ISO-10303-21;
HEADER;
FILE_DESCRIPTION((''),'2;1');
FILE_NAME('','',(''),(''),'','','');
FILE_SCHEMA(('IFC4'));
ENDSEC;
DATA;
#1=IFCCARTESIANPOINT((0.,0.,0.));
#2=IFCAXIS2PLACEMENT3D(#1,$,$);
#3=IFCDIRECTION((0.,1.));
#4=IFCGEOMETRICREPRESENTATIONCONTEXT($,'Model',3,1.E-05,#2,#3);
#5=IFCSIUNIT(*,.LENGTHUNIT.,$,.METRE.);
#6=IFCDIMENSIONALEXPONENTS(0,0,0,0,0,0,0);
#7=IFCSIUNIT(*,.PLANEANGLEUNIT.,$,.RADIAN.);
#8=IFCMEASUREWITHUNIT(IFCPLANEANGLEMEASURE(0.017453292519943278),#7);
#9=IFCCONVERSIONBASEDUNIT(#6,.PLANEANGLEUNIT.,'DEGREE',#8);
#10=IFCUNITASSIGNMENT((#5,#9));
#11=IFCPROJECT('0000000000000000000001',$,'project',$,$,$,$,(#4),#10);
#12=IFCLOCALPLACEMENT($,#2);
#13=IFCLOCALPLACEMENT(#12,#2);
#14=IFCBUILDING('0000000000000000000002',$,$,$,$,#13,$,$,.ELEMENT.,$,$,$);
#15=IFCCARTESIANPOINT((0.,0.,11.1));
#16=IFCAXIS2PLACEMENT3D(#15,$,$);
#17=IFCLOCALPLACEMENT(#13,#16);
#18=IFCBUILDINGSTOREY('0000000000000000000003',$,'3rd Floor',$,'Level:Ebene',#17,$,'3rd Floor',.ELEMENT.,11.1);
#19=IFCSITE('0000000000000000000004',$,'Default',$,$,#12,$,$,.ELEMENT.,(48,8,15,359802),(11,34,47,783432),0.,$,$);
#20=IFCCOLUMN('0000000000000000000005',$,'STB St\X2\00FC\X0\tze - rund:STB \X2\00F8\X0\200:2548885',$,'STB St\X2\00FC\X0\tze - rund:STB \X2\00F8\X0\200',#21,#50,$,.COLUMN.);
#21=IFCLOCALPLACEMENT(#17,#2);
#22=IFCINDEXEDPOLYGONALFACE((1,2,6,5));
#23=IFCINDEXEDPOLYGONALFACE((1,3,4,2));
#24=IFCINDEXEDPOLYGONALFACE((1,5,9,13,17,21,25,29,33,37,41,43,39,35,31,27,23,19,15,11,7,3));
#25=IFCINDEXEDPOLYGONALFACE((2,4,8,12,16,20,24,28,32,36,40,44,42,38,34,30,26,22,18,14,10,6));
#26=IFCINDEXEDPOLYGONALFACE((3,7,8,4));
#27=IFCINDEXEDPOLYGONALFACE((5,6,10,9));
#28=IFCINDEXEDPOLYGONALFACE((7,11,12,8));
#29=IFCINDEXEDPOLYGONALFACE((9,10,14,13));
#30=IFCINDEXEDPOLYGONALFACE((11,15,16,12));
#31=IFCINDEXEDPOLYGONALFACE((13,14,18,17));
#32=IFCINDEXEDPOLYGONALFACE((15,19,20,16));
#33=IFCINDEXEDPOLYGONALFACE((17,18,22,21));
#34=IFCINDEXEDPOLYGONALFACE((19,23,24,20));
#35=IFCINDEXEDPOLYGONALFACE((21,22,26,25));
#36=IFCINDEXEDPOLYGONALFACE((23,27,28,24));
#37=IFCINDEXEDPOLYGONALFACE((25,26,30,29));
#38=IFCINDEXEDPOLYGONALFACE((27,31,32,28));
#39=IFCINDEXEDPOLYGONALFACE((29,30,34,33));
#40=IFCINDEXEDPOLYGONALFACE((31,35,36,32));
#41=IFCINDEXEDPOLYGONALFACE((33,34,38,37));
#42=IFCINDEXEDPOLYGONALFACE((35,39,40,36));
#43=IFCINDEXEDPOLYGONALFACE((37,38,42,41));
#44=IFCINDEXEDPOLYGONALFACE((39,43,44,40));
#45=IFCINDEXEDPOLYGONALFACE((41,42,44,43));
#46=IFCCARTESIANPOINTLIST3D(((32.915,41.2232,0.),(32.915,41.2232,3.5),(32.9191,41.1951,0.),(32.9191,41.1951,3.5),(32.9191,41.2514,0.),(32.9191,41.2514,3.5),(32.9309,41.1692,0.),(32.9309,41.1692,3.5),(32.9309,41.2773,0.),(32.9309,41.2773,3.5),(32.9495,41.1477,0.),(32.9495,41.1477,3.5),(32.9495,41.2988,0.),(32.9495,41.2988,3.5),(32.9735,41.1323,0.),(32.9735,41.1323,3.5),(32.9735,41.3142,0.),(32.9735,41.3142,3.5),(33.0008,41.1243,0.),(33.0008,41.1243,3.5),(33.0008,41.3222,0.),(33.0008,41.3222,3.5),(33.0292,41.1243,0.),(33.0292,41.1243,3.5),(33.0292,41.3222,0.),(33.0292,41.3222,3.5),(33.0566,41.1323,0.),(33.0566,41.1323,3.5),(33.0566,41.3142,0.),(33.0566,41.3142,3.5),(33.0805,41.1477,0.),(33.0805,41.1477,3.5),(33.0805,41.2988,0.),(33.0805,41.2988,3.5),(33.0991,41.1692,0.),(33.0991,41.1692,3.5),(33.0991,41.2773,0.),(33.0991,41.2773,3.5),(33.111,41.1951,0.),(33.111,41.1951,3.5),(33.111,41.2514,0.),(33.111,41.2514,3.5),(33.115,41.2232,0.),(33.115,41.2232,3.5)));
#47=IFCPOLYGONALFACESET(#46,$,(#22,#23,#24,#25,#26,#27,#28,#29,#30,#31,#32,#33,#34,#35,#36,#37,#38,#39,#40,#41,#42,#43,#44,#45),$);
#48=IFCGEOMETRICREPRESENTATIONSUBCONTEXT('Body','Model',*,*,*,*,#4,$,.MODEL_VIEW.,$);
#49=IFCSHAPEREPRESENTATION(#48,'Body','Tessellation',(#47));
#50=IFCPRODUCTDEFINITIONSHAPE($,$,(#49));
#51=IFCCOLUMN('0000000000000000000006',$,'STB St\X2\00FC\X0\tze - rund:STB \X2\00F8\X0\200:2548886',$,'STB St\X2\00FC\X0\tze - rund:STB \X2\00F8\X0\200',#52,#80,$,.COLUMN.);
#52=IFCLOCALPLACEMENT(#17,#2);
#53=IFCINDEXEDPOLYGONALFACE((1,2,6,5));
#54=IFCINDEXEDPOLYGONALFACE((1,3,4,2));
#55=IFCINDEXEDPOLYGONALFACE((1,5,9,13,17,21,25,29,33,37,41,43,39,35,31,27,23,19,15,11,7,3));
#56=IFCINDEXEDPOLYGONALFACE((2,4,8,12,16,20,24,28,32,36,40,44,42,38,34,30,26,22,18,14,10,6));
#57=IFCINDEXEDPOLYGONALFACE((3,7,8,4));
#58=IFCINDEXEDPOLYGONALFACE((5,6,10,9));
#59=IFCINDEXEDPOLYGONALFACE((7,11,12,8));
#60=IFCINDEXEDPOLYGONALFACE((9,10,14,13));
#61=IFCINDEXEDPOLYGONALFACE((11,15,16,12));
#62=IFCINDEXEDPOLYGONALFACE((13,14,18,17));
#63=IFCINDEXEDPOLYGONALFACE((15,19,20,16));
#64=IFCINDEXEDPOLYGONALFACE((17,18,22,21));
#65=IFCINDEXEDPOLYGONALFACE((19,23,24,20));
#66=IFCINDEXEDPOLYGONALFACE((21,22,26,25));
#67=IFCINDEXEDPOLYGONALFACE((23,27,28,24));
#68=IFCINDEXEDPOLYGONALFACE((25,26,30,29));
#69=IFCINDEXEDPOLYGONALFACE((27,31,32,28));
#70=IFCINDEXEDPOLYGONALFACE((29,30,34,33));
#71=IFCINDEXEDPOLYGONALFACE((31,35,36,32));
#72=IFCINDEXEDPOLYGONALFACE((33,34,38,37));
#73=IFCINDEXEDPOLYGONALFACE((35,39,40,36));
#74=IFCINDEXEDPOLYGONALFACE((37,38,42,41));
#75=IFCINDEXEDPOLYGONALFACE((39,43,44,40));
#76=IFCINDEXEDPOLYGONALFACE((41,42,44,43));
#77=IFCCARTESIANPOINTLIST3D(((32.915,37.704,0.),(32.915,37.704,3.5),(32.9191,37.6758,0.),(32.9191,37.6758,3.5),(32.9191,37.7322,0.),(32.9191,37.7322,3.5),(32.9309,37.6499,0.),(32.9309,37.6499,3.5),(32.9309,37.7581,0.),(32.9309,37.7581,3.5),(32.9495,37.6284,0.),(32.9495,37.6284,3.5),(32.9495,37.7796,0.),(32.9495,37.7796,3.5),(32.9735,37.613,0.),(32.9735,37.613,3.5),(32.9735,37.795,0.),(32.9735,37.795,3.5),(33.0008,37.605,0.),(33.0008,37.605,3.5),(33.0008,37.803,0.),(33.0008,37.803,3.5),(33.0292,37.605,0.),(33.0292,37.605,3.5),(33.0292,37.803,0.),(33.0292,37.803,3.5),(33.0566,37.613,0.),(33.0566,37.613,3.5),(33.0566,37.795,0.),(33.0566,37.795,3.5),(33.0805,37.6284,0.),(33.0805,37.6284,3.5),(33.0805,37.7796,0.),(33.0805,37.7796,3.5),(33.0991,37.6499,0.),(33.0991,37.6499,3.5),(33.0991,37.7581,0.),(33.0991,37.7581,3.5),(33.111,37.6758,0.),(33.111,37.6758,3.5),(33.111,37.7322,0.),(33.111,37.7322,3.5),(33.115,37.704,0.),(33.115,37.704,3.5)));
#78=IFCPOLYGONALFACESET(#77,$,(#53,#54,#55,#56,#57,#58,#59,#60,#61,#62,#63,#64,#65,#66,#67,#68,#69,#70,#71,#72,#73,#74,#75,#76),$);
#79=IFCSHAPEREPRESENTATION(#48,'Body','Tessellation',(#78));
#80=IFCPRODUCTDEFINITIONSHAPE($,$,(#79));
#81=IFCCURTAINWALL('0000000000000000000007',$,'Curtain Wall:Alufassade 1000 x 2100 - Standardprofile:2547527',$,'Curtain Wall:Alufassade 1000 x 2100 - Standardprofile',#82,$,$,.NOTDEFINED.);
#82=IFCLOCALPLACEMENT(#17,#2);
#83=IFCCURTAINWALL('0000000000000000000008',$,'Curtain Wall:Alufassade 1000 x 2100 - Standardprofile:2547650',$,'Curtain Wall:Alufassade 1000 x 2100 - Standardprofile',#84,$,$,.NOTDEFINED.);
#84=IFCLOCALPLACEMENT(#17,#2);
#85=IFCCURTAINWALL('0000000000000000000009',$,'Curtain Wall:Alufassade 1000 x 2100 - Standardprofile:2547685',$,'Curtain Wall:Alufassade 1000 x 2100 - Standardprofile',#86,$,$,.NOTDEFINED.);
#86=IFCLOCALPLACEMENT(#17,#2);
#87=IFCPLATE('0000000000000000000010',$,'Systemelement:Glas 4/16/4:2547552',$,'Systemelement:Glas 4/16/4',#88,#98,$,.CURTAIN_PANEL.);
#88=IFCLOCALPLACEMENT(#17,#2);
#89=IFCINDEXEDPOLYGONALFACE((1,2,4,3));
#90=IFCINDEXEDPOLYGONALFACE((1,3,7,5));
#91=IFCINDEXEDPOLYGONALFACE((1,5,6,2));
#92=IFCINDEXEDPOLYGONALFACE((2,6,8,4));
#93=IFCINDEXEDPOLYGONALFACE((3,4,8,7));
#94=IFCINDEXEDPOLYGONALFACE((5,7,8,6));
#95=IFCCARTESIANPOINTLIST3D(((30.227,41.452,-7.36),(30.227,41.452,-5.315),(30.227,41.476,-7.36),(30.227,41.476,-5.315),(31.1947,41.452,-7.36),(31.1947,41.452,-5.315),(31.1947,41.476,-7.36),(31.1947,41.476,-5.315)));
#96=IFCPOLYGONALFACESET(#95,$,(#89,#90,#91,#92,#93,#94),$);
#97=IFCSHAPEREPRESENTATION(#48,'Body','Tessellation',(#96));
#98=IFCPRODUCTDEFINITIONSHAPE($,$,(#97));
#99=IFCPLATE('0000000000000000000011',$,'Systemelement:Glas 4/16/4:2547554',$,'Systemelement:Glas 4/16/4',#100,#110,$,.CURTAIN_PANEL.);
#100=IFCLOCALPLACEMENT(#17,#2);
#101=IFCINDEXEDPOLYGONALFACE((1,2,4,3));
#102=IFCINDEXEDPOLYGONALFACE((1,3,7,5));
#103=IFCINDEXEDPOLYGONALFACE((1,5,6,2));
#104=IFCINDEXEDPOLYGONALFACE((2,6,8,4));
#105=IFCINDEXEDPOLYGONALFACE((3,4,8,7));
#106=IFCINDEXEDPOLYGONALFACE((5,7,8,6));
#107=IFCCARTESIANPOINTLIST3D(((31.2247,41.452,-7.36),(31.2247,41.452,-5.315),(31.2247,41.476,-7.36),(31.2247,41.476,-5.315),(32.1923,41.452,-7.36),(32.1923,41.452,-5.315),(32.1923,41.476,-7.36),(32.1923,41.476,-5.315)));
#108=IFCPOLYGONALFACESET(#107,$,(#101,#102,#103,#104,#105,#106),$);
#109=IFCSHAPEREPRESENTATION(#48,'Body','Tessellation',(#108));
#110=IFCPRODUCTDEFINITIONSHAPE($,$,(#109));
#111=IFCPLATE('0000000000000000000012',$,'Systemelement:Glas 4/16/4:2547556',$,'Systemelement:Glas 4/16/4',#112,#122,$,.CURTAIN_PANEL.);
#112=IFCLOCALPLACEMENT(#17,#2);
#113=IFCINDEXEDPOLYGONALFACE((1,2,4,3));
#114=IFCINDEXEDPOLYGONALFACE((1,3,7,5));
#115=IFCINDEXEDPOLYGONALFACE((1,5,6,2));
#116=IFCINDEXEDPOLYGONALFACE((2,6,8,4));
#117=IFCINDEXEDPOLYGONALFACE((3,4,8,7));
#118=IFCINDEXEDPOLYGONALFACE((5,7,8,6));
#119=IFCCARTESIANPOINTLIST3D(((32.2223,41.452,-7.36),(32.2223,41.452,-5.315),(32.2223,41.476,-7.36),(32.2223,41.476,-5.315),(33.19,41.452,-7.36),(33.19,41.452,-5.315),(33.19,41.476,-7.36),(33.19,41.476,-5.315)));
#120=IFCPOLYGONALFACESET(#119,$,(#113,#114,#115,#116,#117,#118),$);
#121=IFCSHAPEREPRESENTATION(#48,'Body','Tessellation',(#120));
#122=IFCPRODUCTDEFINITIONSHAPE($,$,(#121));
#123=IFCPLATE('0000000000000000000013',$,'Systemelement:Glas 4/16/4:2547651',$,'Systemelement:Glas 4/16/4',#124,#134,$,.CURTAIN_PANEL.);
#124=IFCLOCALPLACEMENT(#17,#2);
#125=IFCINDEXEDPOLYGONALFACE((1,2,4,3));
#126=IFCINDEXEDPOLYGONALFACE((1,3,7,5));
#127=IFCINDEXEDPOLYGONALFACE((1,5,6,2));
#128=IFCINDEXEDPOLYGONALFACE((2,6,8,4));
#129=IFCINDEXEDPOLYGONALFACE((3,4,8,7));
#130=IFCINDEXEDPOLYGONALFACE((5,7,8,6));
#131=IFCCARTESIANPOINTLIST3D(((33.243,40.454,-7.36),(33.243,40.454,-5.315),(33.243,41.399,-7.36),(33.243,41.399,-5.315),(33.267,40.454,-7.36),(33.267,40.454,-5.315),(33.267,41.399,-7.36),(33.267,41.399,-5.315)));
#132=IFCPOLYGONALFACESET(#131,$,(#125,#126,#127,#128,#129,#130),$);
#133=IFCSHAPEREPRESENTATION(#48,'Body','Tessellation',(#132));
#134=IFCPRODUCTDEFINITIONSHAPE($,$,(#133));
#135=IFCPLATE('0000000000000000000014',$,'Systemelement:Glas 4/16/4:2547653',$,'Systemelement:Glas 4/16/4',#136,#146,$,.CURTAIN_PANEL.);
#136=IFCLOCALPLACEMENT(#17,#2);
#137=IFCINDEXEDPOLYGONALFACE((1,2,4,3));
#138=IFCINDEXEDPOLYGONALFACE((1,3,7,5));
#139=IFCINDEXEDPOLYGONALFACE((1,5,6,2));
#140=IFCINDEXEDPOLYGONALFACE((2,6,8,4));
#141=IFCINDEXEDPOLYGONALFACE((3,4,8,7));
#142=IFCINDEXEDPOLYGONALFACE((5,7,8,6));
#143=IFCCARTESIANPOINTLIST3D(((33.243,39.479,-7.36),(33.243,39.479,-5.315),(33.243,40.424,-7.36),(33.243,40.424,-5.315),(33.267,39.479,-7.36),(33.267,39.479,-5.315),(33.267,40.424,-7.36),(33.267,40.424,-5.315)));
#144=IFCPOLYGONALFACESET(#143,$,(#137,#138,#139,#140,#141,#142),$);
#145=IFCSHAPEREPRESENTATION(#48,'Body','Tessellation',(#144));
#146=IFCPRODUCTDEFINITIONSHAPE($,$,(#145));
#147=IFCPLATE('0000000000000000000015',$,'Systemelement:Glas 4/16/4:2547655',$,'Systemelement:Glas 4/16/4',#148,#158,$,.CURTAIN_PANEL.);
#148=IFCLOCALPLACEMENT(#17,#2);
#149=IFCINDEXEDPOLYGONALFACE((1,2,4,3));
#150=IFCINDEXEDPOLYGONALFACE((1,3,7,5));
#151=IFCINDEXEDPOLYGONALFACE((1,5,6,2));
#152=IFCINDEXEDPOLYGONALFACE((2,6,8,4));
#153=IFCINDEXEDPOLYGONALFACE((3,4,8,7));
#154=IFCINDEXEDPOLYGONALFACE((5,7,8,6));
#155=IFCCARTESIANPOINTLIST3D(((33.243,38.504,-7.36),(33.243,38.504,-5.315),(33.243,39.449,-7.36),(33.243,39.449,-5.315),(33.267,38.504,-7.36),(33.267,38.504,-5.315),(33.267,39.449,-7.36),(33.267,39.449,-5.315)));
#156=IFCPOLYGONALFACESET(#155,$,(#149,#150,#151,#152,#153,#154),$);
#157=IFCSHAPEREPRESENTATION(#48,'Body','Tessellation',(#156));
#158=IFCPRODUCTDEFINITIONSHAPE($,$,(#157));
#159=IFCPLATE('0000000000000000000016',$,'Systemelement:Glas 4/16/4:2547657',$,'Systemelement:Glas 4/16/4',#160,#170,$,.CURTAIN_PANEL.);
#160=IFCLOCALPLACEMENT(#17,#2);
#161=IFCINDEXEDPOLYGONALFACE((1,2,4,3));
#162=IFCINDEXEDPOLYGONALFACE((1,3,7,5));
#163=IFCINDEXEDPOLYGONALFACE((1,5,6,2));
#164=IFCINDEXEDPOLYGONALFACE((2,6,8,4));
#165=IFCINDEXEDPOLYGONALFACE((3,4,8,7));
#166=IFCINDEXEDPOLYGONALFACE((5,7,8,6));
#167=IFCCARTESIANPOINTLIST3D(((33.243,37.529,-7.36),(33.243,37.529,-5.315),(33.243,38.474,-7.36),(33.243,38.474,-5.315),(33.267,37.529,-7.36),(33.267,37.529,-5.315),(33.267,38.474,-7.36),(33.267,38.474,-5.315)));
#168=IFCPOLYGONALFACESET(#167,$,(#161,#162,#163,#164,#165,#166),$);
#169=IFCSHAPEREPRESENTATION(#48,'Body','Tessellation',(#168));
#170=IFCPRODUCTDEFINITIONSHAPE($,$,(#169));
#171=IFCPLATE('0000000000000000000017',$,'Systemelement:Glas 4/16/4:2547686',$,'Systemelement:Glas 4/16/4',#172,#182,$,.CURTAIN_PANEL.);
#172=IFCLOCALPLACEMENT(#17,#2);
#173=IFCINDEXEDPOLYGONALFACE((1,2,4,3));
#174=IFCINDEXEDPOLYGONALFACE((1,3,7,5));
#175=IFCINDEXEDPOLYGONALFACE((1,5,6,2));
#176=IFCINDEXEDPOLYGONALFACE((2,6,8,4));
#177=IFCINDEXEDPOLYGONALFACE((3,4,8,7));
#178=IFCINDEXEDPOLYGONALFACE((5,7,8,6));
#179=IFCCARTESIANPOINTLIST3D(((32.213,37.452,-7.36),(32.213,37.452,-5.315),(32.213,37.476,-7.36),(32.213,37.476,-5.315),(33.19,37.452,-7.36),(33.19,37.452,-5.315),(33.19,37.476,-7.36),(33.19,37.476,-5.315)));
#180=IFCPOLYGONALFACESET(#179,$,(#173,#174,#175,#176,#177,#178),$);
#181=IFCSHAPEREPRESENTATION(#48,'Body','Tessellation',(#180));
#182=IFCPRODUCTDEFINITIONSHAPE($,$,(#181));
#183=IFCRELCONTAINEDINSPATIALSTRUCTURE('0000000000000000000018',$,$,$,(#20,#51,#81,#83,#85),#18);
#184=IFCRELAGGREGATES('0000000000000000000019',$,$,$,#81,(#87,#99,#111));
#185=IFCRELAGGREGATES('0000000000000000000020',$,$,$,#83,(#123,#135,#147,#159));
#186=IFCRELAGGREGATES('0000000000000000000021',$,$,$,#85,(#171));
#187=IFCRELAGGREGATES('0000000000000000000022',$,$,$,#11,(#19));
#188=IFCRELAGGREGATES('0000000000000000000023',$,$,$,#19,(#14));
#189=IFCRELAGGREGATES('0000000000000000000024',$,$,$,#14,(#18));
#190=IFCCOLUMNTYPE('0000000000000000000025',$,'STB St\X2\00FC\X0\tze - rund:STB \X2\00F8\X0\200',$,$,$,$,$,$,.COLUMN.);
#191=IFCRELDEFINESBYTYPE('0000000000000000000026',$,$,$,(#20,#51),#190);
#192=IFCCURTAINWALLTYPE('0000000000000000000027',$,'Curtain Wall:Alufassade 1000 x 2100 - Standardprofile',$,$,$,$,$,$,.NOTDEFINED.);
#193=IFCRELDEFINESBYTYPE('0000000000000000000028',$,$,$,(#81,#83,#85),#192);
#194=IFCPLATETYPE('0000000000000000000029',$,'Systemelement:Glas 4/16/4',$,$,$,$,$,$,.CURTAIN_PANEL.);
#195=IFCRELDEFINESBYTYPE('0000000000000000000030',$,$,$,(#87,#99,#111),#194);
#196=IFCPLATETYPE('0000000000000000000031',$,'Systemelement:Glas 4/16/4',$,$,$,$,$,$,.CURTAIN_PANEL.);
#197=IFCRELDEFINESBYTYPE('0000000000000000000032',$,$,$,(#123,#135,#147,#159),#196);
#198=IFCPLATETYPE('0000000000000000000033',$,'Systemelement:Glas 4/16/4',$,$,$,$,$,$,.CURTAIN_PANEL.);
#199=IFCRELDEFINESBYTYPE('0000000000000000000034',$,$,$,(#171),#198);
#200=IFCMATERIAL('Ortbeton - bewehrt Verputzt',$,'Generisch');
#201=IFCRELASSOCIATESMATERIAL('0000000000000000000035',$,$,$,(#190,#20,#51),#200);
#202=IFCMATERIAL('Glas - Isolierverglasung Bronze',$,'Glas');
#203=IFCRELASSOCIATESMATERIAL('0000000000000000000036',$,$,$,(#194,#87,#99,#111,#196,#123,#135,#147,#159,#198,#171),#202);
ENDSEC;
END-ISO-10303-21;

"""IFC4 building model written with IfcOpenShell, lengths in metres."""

from ifc_helpers import new_model, entity, si_unit, converted_unit, direction, frame, origin, place, context, subcontext, project, spatial, arc, indexed_curve, outline, extrude, source, transform, mapped, material, type_object, type_shapes, element, aggregate, save


model = new_model("IFC4")

# Units and contexts
model_context = context("Model", 3, precision=1e-05, world=origin(), true_north=direction((0.0, 1.0)))
body_context = subcontext(model_context, "Body", "Model", "MODEL_VIEW")
ifc_project = project(units=[si_unit("LENGTHUNIT", "METRE"), converted_unit("PLANEANGLEUNIT", "DEGREE", entity("IfcPlaneAngleMeasure", 0.017453292519943278), si_unit("PLANEANGLEUNIT", "RADIAN"), dimensions=[0, 0, 0, 0, 0, 0, 0])], contexts=[model_context])

# Site, building, storey
site_placement = place(None, origin())
site = spatial("IfcSite", under=ifc_project, at=site_placement, Name="Default", CompositionType="ELEMENT", RefLatitude=(48, 8, 15, 359802), RefLongitude=(11, 34, 47, 783432), RefElevation=0.0)
building_placement = place(site_placement, origin())
building = spatial("IfcBuilding", under=site, at=building_placement, CompositionType="ELEMENT")
storey_placement = place(building_placement, frame((0.0, 0.0, 11.1)))
storey = spatial("IfcBuildingStorey", under=building, at=storey_placement, Name="3rd Floor", ObjectType="Level:Ebene", LongName="3rd Floor", CompositionType="ELEMENT", Elevation=11.1)

# Columns
ifc_material_1 = material(Name="Ortbeton - bewehrt Verputzt", Category="Generisch")
column_type_1 = type_object("IfcColumnType", Name="STB Stütze - rund:STB ø200", PredefinedType="COLUMN", material=ifc_material_1)
shared_shape_1 = source(origin(), body_context, "Body", "SweptSolid", [
    extrude(outline(indexed_curve([(-0.1, 0.0), (0.0, -0.1), (0.1, 0.0), (0.0, 0.1)], segments=[arc(1, 2, 3), arc(3, 4, 1)], self_intersect=False)), frame((0.0, 0.0, 11.1)), (0.0, 0.0, 1.0), 3.5),
])
type_shapes(column_type_1, [shared_shape_1])
for number, where, name in (
    (1, (33.015, 41.2232, -11.1), "STB Stütze - rund:STB ø200:2548885"),
    (2, (33.015, 37.704, -11.1), "STB Stütze - rund:STB ø200:2548886"),
):
    element("IfcColumn", number, at=place(storey_placement, frame(where)), inside=storey, type_object=column_type_1, material=ifc_material_1, Name=name, ObjectType="STB Stütze - rund:STB ø200", PredefinedType="COLUMN", context=body_context, shape_type="MappedRepresentation", body=[
        mapped(shared_shape_1, transform((0.0, 0.0, 0.0), scale=1.0)),
    ])

# Curtain walls
curtain_wall_type = type_object("IfcCurtainWallType", Name="Curtain Wall:Alufassade 1000 x 2100 - Standardprofile", PredefinedType="NOTDEFINED")
curtain_wall_1_placement = place(storey_placement, frame((0.0, 0.0, -11.1)))
curtain_wall_1 = element("IfcCurtainWall", 3, at=curtain_wall_1_placement, inside=storey, type_object=curtain_wall_type, Name="Curtain Wall:Alufassade 1000 x 2100 - Standardprofile:2547527", ObjectType="Curtain Wall:Alufassade 1000 x 2100 - Standardprofile", PredefinedType="NOTDEFINED")
curtain_wall_2_placement = place(storey_placement, frame((0.0, 0.0, -11.1)))
curtain_wall_2 = element("IfcCurtainWall", 4, at=curtain_wall_2_placement, inside=storey, type_object=curtain_wall_type, Name="Curtain Wall:Alufassade 1000 x 2100 - Standardprofile:2547650", ObjectType="Curtain Wall:Alufassade 1000 x 2100 - Standardprofile", PredefinedType="NOTDEFINED")

# Curtain wall
curtain_wall_3_placement = place(storey_placement, frame((0.0, 0.0, -11.1)))
curtain_wall_3 = element("IfcCurtainWall", 5, at=curtain_wall_3_placement, inside=storey, type_object=curtain_wall_type, Name="Curtain Wall:Alufassade 1000 x 2100 - Standardprofile:2547685", ObjectType="Curtain Wall:Alufassade 1000 x 2100 - Standardprofile", PredefinedType="NOTDEFINED")

# Plates
ifc_material_2 = material(Name="Glas - Isolierverglasung Bronze", Category="Glas")
plate_type_1 = type_object("IfcPlateType", Name="Systemelement:Glas 4/16/4", PredefinedType="CURTAIN_PANEL", material=ifc_material_2)
shared_shape_2 = source(origin(), body_context, "Body", "SweptSolid", [
    extrude(outline(indexed_curve([(-0.012, -0.4838), (0.012, -0.4838), (0.012, 0.4838), (-0.012, 0.4838), (-0.012, -0.4838)], self_intersect=False)), frame((0.0, 0.0, 0.0), z_axis=(0.0, 0.0, 1.0), x_axis=(0.0, 1.0, 0.0)), (0.0, 0.0, 1.0), 2.045),
])
type_shapes(plate_type_1, [shared_shape_2])
plate_1_placement = place(curtain_wall_1_placement, frame((30.7108, 41.464, 3.74)))
plate_1 = element("IfcPlate", 6, at=plate_1_placement, type_object=plate_type_1, material=ifc_material_2, Name="Systemelement:Glas 4/16/4:2547552", ObjectType="Systemelement:Glas 4/16/4", PredefinedType="CURTAIN_PANEL", context=body_context, shape_type="MappedRepresentation", body=[
    mapped(shared_shape_2, transform((0.0, 0.0, 0.0), scale=1.0)),
])
plate_2_placement = place(curtain_wall_1_placement, frame((31.7085, 41.464, 3.74)))
plate_2 = element("IfcPlate", 7, at=plate_2_placement, type_object=plate_type_1, material=ifc_material_2, Name="Systemelement:Glas 4/16/4:2547554", ObjectType="Systemelement:Glas 4/16/4", PredefinedType="CURTAIN_PANEL", context=body_context, shape_type="MappedRepresentation", body=[
    mapped(shared_shape_2, transform((0.0, 0.0, 0.0), scale=1.0)),
])
plate_3_placement = place(curtain_wall_1_placement, frame((32.7062, 41.464, 3.74)))
plate_3 = element("IfcPlate", 8, at=plate_3_placement, type_object=plate_type_1, material=ifc_material_2, Name="Systemelement:Glas 4/16/4:2547556", ObjectType="Systemelement:Glas 4/16/4", PredefinedType="CURTAIN_PANEL", context=body_context, shape_type="MappedRepresentation", body=[
    mapped(shared_shape_2, transform((0.0, 0.0, 0.0), scale=1.0)),
])
aggregate(curtain_wall_1, [plate_1, plate_2, plate_3])
plate_type_2 = type_object("IfcPlateType", Name="Systemelement:Glas 4/16/4", PredefinedType="CURTAIN_PANEL", material=ifc_material_2)
shared_shape_3 = source(origin(), body_context, "Body", "SweptSolid", [
    extrude(outline(indexed_curve([(-0.012, -0.4725), (0.012, -0.4725), (0.012, 0.4725), (-0.012, 0.4725), (-0.012, -0.4725)], self_intersect=False)), frame((0.0, 0.0, 0.0), z_axis=(0.0, 0.0, 1.0), x_axis=(0.0, 1.0, 0.0)), (0.0, 0.0, 1.0), 2.045),
])
type_shapes(plate_type_2, [shared_shape_3])
plate_4_placement = place(curtain_wall_2_placement, frame((33.255, 40.9265, 3.74), z_axis=(0.0, 0.0, 1.0), x_axis=(0.0, -1.0, 0.0)))
plate_4 = element("IfcPlate", 9, at=plate_4_placement, type_object=plate_type_2, material=ifc_material_2, Name="Systemelement:Glas 4/16/4:2547651", ObjectType="Systemelement:Glas 4/16/4", PredefinedType="CURTAIN_PANEL", context=body_context, shape_type="MappedRepresentation", body=[
    mapped(shared_shape_3, transform((0.0, 0.0, 0.0), scale=1.0)),
])
plate_5_placement = place(curtain_wall_2_placement, frame((33.255, 39.9515, 3.74), z_axis=(0.0, 0.0, 1.0), x_axis=(0.0, -1.0, 0.0)))
plate_5 = element("IfcPlate", 10, at=plate_5_placement, type_object=plate_type_2, material=ifc_material_2, Name="Systemelement:Glas 4/16/4:2547653", ObjectType="Systemelement:Glas 4/16/4", PredefinedType="CURTAIN_PANEL", context=body_context, shape_type="MappedRepresentation", body=[
    mapped(shared_shape_3, transform((0.0, 0.0, 0.0), scale=1.0)),
])
plate_6_placement = place(curtain_wall_2_placement, frame((33.255, 38.9765, 3.74), z_axis=(0.0, 0.0, 1.0), x_axis=(0.0, -1.0, 0.0)))
plate_6 = element("IfcPlate", 11, at=plate_6_placement, type_object=plate_type_2, material=ifc_material_2, Name="Systemelement:Glas 4/16/4:2547655", ObjectType="Systemelement:Glas 4/16/4", PredefinedType="CURTAIN_PANEL", context=body_context, shape_type="MappedRepresentation", body=[
    mapped(shared_shape_3, transform((0.0, 0.0, 0.0), scale=1.0)),
])
plate_7_placement = place(curtain_wall_2_placement, frame((33.255, 38.0015, 3.74), z_axis=(0.0, 0.0, 1.0), x_axis=(0.0, -1.0, 0.0)))
plate_7 = element("IfcPlate", 12, at=plate_7_placement, type_object=plate_type_2, material=ifc_material_2, Name="Systemelement:Glas 4/16/4:2547657", ObjectType="Systemelement:Glas 4/16/4", PredefinedType="CURTAIN_PANEL", context=body_context, shape_type="MappedRepresentation", body=[
    mapped(shared_shape_3, transform((0.0, 0.0, 0.0), scale=1.0)),
])
aggregate(curtain_wall_2, [plate_4, plate_5, plate_6, plate_7])
plate_type_3 = type_object("IfcPlateType", Name="Systemelement:Glas 4/16/4", PredefinedType="CURTAIN_PANEL", material=ifc_material_2)
shared_shape_4 = source(origin(), body_context, "Body", "SweptSolid", [
    extrude(outline(indexed_curve([(-0.012, -0.4885), (0.012, -0.4885), (0.012, 0.4885), (-0.012, 0.4885), (-0.012, -0.4885)], self_intersect=False)), frame((0.0, 0.0, 0.0), z_axis=(0.0, 0.0, 1.0), x_axis=(0.0, 1.0, 0.0)), (0.0, 0.0, 1.0), 2.045),
])
type_shapes(plate_type_3, [shared_shape_4])
plate_8_placement = place(curtain_wall_3_placement, frame((32.7015, 37.464, 3.74), z_axis=(0.0, 0.0, 1.0), x_axis=(-1.0, 0.0, 0.0)))
plate_8 = element("IfcPlate", 13, at=plate_8_placement, type_object=plate_type_3, material=ifc_material_2, Name="Systemelement:Glas 4/16/4:2547686", ObjectType="Systemelement:Glas 4/16/4", PredefinedType="CURTAIN_PANEL", context=body_context, shape_type="MappedRepresentation", body=[
    mapped(shared_shape_4, transform((0.0, 0.0, 0.0), scale=1.0)),
])
aggregate(curtain_wall_3, [plate_8])

save(model, "model.ifc")
